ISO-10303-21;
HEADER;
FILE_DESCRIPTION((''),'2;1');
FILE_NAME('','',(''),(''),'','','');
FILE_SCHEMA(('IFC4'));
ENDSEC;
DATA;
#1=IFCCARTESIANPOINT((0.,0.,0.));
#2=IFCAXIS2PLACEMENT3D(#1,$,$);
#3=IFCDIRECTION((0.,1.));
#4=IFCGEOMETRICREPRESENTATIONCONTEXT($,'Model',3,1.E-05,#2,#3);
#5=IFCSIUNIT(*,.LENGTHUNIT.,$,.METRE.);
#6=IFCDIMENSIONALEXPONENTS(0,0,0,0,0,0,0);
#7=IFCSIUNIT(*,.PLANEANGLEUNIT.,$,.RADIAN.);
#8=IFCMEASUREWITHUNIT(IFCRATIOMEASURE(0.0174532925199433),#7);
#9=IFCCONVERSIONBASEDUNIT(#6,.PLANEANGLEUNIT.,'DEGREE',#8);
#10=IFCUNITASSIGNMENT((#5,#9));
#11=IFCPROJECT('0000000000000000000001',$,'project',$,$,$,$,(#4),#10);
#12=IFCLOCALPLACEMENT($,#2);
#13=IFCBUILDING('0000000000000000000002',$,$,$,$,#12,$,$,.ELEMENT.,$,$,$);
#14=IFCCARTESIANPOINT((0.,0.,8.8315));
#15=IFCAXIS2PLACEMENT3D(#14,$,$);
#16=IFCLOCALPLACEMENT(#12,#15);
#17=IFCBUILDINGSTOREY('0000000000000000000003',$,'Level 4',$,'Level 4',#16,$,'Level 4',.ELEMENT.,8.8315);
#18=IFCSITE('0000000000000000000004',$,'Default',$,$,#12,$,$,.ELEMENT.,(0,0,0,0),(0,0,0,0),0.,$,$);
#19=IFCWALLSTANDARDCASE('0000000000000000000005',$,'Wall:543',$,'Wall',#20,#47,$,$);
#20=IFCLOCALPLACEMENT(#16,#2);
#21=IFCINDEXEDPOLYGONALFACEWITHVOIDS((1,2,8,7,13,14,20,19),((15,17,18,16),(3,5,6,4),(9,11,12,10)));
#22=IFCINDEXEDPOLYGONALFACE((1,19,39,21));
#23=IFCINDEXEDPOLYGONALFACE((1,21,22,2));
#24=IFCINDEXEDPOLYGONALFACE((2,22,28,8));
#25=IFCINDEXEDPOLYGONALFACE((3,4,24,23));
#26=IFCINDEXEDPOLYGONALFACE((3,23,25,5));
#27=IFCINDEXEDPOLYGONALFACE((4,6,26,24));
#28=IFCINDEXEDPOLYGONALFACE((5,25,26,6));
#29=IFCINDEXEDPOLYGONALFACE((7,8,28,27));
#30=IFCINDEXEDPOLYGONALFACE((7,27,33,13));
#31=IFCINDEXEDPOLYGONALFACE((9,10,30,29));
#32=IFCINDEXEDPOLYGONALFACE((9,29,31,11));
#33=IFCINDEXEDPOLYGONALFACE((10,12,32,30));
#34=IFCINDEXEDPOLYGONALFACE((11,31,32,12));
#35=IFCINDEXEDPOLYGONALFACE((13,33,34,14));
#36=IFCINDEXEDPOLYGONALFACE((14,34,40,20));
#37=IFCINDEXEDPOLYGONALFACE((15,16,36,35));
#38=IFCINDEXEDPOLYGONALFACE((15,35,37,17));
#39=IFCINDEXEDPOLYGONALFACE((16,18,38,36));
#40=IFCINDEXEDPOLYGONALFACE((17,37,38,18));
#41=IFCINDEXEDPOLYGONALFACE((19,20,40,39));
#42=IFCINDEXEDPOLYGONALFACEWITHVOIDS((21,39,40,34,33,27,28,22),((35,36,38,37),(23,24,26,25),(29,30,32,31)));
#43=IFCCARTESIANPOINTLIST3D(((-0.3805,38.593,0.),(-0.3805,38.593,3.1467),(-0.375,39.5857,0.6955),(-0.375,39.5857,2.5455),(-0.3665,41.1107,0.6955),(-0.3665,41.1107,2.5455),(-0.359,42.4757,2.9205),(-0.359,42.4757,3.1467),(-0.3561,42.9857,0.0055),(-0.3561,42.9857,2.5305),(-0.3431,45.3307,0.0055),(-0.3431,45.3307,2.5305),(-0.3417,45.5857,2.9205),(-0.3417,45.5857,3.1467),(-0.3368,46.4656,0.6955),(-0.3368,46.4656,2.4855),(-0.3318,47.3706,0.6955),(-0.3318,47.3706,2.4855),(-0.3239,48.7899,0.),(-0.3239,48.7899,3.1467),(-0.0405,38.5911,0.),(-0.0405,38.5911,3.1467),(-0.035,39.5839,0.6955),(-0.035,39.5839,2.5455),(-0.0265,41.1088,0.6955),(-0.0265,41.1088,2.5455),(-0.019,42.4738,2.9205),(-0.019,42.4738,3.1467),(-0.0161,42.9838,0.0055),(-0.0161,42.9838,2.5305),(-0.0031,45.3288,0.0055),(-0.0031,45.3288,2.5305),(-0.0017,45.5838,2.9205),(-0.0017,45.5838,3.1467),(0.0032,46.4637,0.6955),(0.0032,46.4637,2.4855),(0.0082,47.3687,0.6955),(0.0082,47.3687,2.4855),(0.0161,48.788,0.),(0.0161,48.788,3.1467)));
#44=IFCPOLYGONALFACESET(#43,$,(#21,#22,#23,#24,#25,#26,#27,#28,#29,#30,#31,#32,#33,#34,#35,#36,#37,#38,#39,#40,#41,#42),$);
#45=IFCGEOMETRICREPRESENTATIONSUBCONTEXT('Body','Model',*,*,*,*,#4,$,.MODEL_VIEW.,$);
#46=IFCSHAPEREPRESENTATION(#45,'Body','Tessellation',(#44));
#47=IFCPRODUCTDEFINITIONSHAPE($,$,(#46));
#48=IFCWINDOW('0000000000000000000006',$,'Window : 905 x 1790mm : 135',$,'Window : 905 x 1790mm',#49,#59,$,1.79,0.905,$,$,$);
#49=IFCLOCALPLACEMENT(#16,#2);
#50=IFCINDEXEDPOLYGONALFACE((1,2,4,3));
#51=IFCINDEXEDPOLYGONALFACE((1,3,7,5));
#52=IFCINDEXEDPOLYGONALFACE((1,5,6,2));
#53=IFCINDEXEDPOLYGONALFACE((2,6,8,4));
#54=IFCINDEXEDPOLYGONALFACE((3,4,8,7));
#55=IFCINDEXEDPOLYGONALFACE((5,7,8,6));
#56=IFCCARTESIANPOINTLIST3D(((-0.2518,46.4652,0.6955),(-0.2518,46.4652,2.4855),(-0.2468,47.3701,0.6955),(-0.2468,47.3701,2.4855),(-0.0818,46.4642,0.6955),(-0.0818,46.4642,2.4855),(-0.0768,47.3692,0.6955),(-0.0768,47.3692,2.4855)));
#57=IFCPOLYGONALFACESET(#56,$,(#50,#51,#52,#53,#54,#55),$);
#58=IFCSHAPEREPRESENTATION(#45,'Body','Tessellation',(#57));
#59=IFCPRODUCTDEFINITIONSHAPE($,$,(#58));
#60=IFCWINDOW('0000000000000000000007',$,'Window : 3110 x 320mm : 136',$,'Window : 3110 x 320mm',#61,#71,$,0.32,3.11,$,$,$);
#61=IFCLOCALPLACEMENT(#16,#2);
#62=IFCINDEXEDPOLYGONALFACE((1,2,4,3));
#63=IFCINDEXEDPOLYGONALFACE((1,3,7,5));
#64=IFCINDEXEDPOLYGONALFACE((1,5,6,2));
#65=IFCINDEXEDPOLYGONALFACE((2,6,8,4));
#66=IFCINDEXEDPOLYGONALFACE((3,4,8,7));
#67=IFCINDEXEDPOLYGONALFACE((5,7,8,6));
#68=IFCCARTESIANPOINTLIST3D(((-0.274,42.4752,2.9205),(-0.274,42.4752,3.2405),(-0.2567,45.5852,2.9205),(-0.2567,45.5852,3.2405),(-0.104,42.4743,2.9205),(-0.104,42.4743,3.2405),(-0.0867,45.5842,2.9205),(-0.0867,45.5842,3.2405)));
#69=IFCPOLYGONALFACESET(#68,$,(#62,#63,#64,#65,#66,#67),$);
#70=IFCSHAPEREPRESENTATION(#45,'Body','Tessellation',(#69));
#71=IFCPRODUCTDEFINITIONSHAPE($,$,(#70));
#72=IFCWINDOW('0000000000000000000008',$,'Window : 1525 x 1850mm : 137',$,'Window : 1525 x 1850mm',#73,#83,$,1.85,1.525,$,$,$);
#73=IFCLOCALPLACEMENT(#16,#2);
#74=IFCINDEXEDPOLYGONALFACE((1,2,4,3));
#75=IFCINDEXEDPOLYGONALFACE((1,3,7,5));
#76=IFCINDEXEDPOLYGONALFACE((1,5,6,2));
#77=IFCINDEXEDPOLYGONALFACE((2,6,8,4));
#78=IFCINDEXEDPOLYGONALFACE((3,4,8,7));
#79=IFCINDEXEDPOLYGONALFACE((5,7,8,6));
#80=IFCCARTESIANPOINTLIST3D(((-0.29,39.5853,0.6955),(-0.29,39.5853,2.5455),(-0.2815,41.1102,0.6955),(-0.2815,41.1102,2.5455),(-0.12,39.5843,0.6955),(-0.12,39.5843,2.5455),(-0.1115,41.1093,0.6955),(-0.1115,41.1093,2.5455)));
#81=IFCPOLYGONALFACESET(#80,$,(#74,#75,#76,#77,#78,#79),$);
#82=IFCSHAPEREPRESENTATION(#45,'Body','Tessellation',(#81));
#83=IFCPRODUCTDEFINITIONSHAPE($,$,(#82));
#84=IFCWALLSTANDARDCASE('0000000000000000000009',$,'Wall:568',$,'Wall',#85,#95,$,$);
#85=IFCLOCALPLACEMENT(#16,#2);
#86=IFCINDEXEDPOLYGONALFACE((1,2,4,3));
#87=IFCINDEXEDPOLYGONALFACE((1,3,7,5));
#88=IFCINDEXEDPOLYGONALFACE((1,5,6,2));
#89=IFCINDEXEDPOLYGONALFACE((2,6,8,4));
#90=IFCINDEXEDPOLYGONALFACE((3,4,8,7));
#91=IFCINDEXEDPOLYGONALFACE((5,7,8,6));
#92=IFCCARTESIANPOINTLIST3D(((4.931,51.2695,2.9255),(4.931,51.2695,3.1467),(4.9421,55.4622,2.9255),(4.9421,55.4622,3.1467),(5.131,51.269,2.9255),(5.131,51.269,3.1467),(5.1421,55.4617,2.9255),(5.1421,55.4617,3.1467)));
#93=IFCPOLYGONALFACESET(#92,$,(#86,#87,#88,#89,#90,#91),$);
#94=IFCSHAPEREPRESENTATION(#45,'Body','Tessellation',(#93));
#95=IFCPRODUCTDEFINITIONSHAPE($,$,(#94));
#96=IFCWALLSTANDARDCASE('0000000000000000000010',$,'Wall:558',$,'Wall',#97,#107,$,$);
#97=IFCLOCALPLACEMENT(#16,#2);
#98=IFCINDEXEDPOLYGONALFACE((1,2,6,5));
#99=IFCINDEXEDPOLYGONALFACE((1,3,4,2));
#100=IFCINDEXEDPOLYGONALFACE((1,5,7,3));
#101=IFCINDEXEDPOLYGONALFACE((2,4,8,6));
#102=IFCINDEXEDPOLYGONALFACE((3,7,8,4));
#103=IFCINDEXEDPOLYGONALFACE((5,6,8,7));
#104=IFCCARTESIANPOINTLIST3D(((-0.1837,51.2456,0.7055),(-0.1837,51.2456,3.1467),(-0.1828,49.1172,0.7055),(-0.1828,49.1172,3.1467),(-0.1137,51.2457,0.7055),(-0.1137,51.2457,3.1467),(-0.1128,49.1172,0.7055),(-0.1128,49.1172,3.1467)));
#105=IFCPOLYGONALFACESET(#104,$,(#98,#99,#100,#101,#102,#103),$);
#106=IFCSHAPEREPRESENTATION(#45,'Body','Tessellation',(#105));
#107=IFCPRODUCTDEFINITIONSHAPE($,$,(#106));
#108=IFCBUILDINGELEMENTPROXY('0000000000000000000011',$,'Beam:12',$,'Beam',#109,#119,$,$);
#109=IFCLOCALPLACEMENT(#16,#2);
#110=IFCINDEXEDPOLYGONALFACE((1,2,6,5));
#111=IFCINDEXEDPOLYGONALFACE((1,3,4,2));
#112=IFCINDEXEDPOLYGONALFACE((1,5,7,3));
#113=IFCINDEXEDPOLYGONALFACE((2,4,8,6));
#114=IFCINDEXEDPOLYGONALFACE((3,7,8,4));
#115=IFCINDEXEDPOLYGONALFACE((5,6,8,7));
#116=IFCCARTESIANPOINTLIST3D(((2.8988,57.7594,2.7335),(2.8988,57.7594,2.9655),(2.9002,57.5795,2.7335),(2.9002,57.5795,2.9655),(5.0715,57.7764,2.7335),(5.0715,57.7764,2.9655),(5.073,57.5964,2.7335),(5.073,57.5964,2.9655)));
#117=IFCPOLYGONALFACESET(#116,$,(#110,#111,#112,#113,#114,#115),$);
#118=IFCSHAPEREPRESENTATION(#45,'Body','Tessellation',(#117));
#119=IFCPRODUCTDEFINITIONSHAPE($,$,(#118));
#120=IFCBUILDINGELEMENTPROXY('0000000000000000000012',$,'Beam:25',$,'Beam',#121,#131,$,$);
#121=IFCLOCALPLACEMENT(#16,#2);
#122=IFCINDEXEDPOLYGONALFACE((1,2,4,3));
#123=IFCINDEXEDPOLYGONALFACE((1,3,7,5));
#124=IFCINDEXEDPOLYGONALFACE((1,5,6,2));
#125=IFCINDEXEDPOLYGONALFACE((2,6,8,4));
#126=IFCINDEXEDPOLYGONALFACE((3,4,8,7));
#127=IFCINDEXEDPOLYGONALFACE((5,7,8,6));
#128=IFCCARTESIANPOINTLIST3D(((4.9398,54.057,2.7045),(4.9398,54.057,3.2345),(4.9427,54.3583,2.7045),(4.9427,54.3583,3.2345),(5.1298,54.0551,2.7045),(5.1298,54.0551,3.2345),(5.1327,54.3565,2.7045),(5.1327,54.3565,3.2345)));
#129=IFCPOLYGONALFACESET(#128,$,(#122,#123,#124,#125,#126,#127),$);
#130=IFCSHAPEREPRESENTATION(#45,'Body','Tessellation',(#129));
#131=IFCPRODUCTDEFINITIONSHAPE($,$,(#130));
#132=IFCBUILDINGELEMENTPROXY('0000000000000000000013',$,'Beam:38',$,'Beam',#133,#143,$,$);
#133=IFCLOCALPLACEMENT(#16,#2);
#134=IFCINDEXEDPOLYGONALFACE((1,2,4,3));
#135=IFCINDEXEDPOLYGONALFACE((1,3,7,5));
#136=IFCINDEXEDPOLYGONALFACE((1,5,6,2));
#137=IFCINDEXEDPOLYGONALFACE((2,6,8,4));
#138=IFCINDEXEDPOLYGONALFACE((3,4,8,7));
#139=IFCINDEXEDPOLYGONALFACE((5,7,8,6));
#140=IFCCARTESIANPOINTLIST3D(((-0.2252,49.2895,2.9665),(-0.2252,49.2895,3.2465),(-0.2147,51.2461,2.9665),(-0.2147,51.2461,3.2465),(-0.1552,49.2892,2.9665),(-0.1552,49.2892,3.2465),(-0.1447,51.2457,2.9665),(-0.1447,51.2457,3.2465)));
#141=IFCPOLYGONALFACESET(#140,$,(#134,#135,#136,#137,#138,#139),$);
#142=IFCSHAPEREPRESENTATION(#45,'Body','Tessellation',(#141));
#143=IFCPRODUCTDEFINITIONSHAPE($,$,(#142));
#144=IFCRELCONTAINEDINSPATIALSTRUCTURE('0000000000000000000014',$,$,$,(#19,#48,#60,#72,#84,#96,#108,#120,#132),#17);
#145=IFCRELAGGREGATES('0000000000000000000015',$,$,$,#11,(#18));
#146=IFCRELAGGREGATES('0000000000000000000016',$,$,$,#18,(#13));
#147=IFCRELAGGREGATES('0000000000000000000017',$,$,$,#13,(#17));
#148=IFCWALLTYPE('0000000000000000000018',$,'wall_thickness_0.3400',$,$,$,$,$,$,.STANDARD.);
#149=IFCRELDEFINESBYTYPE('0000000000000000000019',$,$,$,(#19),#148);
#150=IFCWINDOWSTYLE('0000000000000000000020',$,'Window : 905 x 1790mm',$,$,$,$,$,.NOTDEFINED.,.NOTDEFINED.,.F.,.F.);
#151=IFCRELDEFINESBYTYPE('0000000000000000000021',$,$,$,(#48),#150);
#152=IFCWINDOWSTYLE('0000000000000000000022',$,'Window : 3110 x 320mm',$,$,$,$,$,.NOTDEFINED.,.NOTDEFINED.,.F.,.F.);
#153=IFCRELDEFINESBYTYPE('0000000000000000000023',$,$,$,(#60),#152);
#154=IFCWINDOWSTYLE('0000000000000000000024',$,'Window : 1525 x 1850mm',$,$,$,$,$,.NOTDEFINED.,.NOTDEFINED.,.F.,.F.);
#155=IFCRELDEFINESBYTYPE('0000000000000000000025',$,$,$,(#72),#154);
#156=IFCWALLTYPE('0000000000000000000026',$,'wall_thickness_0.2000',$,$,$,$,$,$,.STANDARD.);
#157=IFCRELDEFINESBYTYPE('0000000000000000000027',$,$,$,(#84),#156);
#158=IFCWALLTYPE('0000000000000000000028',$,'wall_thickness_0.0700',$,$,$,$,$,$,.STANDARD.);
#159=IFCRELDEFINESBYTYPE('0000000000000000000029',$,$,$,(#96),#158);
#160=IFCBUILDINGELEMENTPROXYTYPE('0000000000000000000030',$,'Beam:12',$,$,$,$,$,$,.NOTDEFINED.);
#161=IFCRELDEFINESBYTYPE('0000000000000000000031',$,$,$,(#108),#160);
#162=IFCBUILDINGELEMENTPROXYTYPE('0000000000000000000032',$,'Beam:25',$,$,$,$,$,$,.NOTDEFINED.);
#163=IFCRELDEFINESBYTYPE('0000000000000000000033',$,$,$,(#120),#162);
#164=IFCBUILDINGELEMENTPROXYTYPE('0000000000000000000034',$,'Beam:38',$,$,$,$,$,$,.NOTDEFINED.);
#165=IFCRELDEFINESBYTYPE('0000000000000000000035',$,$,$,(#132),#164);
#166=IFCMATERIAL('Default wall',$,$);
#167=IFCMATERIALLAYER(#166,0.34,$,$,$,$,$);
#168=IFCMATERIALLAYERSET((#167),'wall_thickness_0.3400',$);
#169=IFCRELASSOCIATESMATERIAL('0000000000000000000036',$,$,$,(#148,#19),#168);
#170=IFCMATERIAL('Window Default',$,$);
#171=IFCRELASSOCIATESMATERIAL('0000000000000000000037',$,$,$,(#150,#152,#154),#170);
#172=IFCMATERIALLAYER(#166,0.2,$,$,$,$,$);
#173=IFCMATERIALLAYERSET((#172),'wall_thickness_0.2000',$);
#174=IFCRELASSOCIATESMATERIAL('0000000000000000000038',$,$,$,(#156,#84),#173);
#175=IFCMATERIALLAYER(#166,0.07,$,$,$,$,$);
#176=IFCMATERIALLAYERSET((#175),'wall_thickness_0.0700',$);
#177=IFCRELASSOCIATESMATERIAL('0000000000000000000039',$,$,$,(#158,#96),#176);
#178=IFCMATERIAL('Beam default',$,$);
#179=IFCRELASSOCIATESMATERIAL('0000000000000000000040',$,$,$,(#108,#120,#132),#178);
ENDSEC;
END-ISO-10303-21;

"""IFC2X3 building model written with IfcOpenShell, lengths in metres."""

from ifc_helpers import new_model, entity, si_unit, converted_unit, direction, frame, frame_2d, origin, origin_2d_with_axis, place, context, subcontext, project, spatial, polyline, rectangle, outline, extrude, source, transform, mapped, material, layer, layer_set, layer_usage, type_object, type_shapes, element, fill, save


model = new_model("IFC2X3")

# Units and contexts
model_context = context("Model", 3, precision=1e-05, world=origin(), true_north=direction((0.0, 1.0)))
body_context = subcontext(model_context, "Body", "Model", "MODEL_VIEW")
ifc_project = project(units=[si_unit("LENGTHUNIT", "METRE"), converted_unit("PLANEANGLEUNIT", "DEGREE", entity("IfcRatioMeasure", 0.0174532925199433), si_unit("PLANEANGLEUNIT", "RADIAN"), dimensions=[0, 0, 0, 0, 0, 0, 0])], contexts=[model_context])

# Site, building, storey
placement_1 = place(None, origin())
site = spatial("IfcSite", under=ifc_project, at=placement_1, Name="Default", CompositionType="ELEMENT", RefLatitude=(0, 0, 0, 0), RefLongitude=(0, 0, 0, 0), RefElevation=0.0)
building = spatial("IfcBuilding", under=site, at=placement_1, CompositionType="ELEMENT")
storey_placement = place(placement_1, frame((0.0, 0.0, 8.8315)))
storey = spatial("IfcBuildingStorey", under=building, at=storey_placement, Name="Level 4", ObjectType="Level 4", LongName="Level 4", CompositionType="ELEMENT", Elevation=8.8315)

# Shared definitions
ifc_material_1 = material(Name="Default wall")

# Wall, openings, windows
ifc_layer_1 = layer(ifc_material_1, 0.34)
ifc_layer_set_1 = layer_set([ifc_layer_1], Name="wall_thickness_0.3400")
ifc_layer_usage_1 = layer_usage(ifc_layer_set_1, "AXIS2", "POSITIVE", -0.17)
wall_type_1 = type_object("IfcWallType", Name="wall_thickness_0.3400", PredefinedType="STANDARD", material=ifc_layer_set_1)
wall_1_placement = place(storey_placement, frame((-0.1539, 48.7889, 0.0), z_axis=(0.0, 0.0, 1.0), x_axis=(-0.005555, -0.999985, 0.0)))
wall_1 = element("IfcWallStandardCase", 1, at=wall_1_placement, inside=storey, type_object=wall_type_1, material=ifc_layer_usage_1, Name="Wall:543", ObjectType="Wall", context=body_context, shape_type="SweptSolid", body=[
    extrude(outline(polyline([(10.197, -0.17), (10.197, 0.17), (0.0, 0.17), (0.0, -0.17), (10.197, -0.17)])), origin(), (0.0, 0.0, 1.0), 3.1467),
])
opening_1_placement = place(wall_1_placement, frame((3.4593, -0.17, 0.0055)))
element("IfcOpeningElement", 2, at=opening_1_placement, cuts=wall_1, ObjectType="Opening", context=body_context, shape_type="SweptSolid", body=[
    extrude(rectangle(XDim=2.345, YDim=2.525, at=frame_2d((1.2625, 1.1725), x_axis=(0.0, 1.0))), frame((0.0, 0.0, 0.0), z_axis=(0.0, 1.0, 0.0), x_axis=(0.0, 0.0, 1.0)), (0.0, 0.0, 1.0), 0.34),
])
opening_2_placement = place(wall_1_placement, frame((1.4193, -0.17, 0.6955)))
opening_2 = element("IfcOpeningElement", 3, at=opening_2_placement, cuts=wall_1, ObjectType="Opening", context=body_context, shape_type="SweptSolid", body=[
    extrude(rectangle(XDim=0.905, YDim=1.79, at=frame_2d((0.895, 0.4525), x_axis=(0.0, 1.0))), frame((0.0, 0.0, 0.0), z_axis=(0.0, 1.0, 0.0), x_axis=(0.0, 0.0, 1.0)), (0.0, 0.0, 1.0), 0.34),
])
opening_3_placement = place(wall_1_placement, frame((3.2043, -0.17, 2.9205)))
opening_3 = element("IfcOpeningElement", 4, at=opening_3_placement, cuts=wall_1, ObjectType="Opening", context=body_context, shape_type="SweptSolid", body=[
    extrude(rectangle(XDim=3.11, YDim=0.32, at=frame_2d((0.16, 1.555), x_axis=(0.0, 1.0))), frame((0.0, 0.0, 0.0), z_axis=(0.0, 1.0, 0.0), x_axis=(0.0, 0.0, 1.0)), (0.0, 0.0, 1.0), 0.34),
])
opening_4_placement = place(wall_1_placement, frame((7.6793, -0.17, 0.6955)))
opening_4 = element("IfcOpeningElement", 5, at=opening_4_placement, cuts=wall_1, ObjectType="Opening", context=body_context, shape_type="SweptSolid", body=[
    extrude(rectangle(XDim=1.525, YDim=1.85, at=frame_2d((0.925, 0.7625), x_axis=(0.0, 1.0))), frame((0.0, 0.0, 0.0), z_axis=(0.0, 1.0, 0.0), x_axis=(0.0, 0.0, 1.0)), (0.0, 0.0, 1.0), 0.34),
])
ifc_material_2 = material(Name="Window Default")
window_style_1 = type_object("IfcWindowStyle", Name="Window : 905 x 1790mm", ConstructionType="NOTDEFINED", OperationType="NOTDEFINED", ParameterTakesPrecedence=False, Sizeable=False, material=ifc_material_2)
shared_shape_1 = source(origin(), body_context, "Body", "SweptSolid", [
    extrude(rectangle(XDim=0.17, YDim=0.905, at=origin_2d_with_axis()), frame((0.4525, 0.17, 0.0), z_axis=(0.0, 0.0, 1.0), x_axis=(0.0, 1.0, 0.0)), (0.0, 0.0, 1.0), 1.79),
])
type_shapes(window_style_1, [shared_shape_1])
window_1_placement = place(opening_2_placement, origin())
window_1 = element("IfcWindow", 6, at=window_1_placement, inside=storey, type_object=window_style_1, Name="Window : 905 x 1790mm : 135", ObjectType="Window : 905 x 1790mm", OverallHeight=1.79, OverallWidth=0.905, context=body_context, shape_type="MappedRepresentation", body=[
    mapped(shared_shape_1, transform((0.0, 0.0, 0.0), scale=1.0)),
])
fill(opening_2, window_1)
window_style_2 = type_object("IfcWindowStyle", Name="Window : 3110 x 320mm", ConstructionType="NOTDEFINED", OperationType="NOTDEFINED", ParameterTakesPrecedence=False, Sizeable=False, material=ifc_material_2)
shared_shape_2 = source(origin(), body_context, "Body", "SweptSolid", [
    extrude(rectangle(XDim=0.17, YDim=3.11, at=origin_2d_with_axis()), frame((1.555, 0.17, 0.0), z_axis=(0.0, 0.0, 1.0), x_axis=(0.0, 1.0, 0.0)), (0.0, 0.0, 1.0), 0.32),
])
type_shapes(window_style_2, [shared_shape_2])
window_2_placement = place(opening_3_placement, origin())
window_2 = element("IfcWindow", 7, at=window_2_placement, inside=storey, type_object=window_style_2, Name="Window : 3110 x 320mm : 136", ObjectType="Window : 3110 x 320mm", OverallHeight=0.32, OverallWidth=3.11, context=body_context, shape_type="MappedRepresentation", body=[
    mapped(shared_shape_2, transform((0.0, 0.0, 0.0), scale=1.0)),
])
fill(opening_3, window_2)
window_style_3 = type_object("IfcWindowStyle", Name="Window : 1525 x 1850mm", ConstructionType="NOTDEFINED", OperationType="NOTDEFINED", ParameterTakesPrecedence=False, Sizeable=False, material=ifc_material_2)
shared_shape_3 = source(origin(), body_context, "Body", "SweptSolid", [
    extrude(rectangle(XDim=0.17, YDim=1.525, at=origin_2d_with_axis()), frame((0.7625, 0.17, 0.0), z_axis=(0.0, 0.0, 1.0), x_axis=(0.0, 1.0, 0.0)), (0.0, 0.0, 1.0), 1.85),
])
type_shapes(window_style_3, [shared_shape_3])
window_3_placement = place(opening_4_placement, origin())
window_3 = element("IfcWindow", 8, at=window_3_placement, inside=storey, type_object=window_style_3, Name="Window : 1525 x 1850mm : 137", ObjectType="Window : 1525 x 1850mm", OverallHeight=1.85, OverallWidth=1.525, context=body_context, shape_type="MappedRepresentation", body=[
    mapped(shared_shape_3, transform((0.0, 0.0, 0.0), scale=1.0)),
])
fill(opening_4, window_3)

# Walls
ifc_layer_2 = layer(ifc_material_1, 0.2)
ifc_layer_set_2 = layer_set([ifc_layer_2], Name="wall_thickness_0.2000")
ifc_layer_usage_2 = layer_usage(ifc_layer_set_2, "AXIS2", "POSITIVE", -0.1)
wall_type_2 = type_object("IfcWallType", Name="wall_thickness_0.2000", PredefinedType="STANDARD", material=ifc_layer_set_2)
placement_2 = place(placement_1, frame((0.0, 0.0, 11.757)))
wall_2_placement = place(placement_2, frame((5.0421, 55.4619, 0.0), z_axis=(0.0, 0.0, 1.0), x_axis=(-0.002647, -0.999996, 0.0)))
element("IfcWallStandardCase", 9, at=wall_2_placement, inside=storey, type_object=wall_type_2, material=ifc_layer_usage_2, Name="Wall:568", ObjectType="Wall", context=body_context, shape_type="SweptSolid", body=[
    extrude(outline(polyline([(4.1927, -0.1), (4.1927, 0.1), (0.0, 0.1), (0.0, -0.1), (4.1927, -0.1)])), origin(), (0.0, 0.0, 1.0), 0.2212),
])
ifc_layer_3 = layer(ifc_material_1, 0.07)
ifc_layer_set_3 = layer_set([ifc_layer_3], Name="wall_thickness_0.0700")
ifc_layer_usage_3 = layer_usage(ifc_layer_set_3, "AXIS2", "POSITIVE", -0.035)
wall_type_3 = type_object("IfcWallType", Name="wall_thickness_0.0700", PredefinedType="STANDARD", material=ifc_layer_set_3)
placement_3 = place(placement_1, frame((0.0, 0.0, 9.537)))
wall_3_placement = place(placement_3, frame((-0.1487, 51.2457, 0.0), z_axis=(0.0, 0.0, 1.0), x_axis=(0.00041, -1.0, 0.0)))
element("IfcWallStandardCase", 10, at=wall_3_placement, inside=storey, type_object=wall_type_3, material=ifc_layer_usage_3, Name="Wall:558", ObjectType="Wall", context=body_context, shape_type="SweptSolid", body=[
    extrude(outline(polyline([(2.1284, -0.035), (2.1284, 0.035), (0.0, 0.035), (0.0, -0.035), (2.1284, -0.035)])), origin(), (0.0, 0.0, 1.0), 2.4412),
])

# Building element proxies
ifc_material_3 = material(Name="Beam default")
building_element_proxy_type_1 = type_object("IfcBuildingElementProxyType", Name="Beam:12", PredefinedType="NOTDEFINED")
shared_shape_4 = source(origin(), body_context, "Body", "SweptSolid", [
    extrude(outline(polyline([(2.1728, -0.09), (2.1728, 0.09), (0.0, 0.09), (0.0, -0.09), (2.1728, -0.09)])), origin(), (0.0, 0.0, 1.0), 0.232),
])
type_shapes(building_element_proxy_type_1, [shared_shape_4])
placement_4 = place(placement_1, frame((0.0, 0.0, 11.565)))
proxy_1_placement = place(placement_4, frame((2.8995, 57.6695, 0.0), z_axis=(0.0, 0.0, 1.0), x_axis=(0.99997, 0.007807, 0.0)))
element("IfcBuildingElementProxy", 11, at=proxy_1_placement, inside=storey, type_object=building_element_proxy_type_1, material=ifc_material_3, Name="Beam:12", ObjectType="Beam", context=body_context, shape_type="MappedRepresentation", body=[
    mapped(shared_shape_4, transform((0.0, 0.0, 0.0), scale=1.0)),
])
building_element_proxy_type_2 = type_object("IfcBuildingElementProxyType", Name="Beam:25", PredefinedType="NOTDEFINED")
shared_shape_5 = source(origin(), body_context, "Body", "SweptSolid", [
    extrude(outline(polyline([(0.3013, -0.095), (0.3013, 0.095), (0.0, 0.095), (0.0, -0.095), (0.3013, -0.095)])), origin(), (0.0, 0.0, 1.0), 0.53),
])
type_shapes(building_element_proxy_type_2, [shared_shape_5])
placement_5 = place(placement_1, frame((0.0, 0.0, 11.536)))
proxy_2_placement = place(placement_5, frame((5.0377, 54.3574, 0.0), z_axis=(0.0, 0.0, 1.0), x_axis=(-0.009667, -0.999953, 0.0)))
element("IfcBuildingElementProxy", 12, at=proxy_2_placement, inside=storey, type_object=building_element_proxy_type_2, material=ifc_material_3, Name="Beam:25", ObjectType="Beam", context=body_context, shape_type="MappedRepresentation", body=[
    mapped(shared_shape_5, transform((0.0, 0.0, 0.0), scale=1.0)),
])
building_element_proxy_type_3 = type_object("IfcBuildingElementProxyType", Name="Beam:38", PredefinedType="NOTDEFINED")
shared_shape_6 = source(origin(), body_context, "Body", "SweptSolid", [
    extrude(outline(polyline([(1.9566, -0.035), (1.9566, 0.035), (0.0, 0.035), (0.0, -0.035), (1.9566, -0.035)])), origin(), (0.0, 0.0, 1.0), 0.28),
])
type_shapes(building_element_proxy_type_3, [shared_shape_6])
placement_6 = place(placement_1, frame((0.0, 0.0, 11.798)))
proxy_3_placement = place(placement_6, frame((-0.1797, 51.2459, 0.0), z_axis=(0.0, 0.0, 1.0), x_axis=(-0.005342, -0.999986, 0.0)))
element("IfcBuildingElementProxy", 13, at=proxy_3_placement, inside=storey, type_object=building_element_proxy_type_3, material=ifc_material_3, Name="Beam:38", ObjectType="Beam", context=body_context, shape_type="MappedRepresentation", body=[
    mapped(shared_shape_6, transform((0.0, 0.0, 0.0), scale=1.0)),
])

save(model, "model.ifc")
